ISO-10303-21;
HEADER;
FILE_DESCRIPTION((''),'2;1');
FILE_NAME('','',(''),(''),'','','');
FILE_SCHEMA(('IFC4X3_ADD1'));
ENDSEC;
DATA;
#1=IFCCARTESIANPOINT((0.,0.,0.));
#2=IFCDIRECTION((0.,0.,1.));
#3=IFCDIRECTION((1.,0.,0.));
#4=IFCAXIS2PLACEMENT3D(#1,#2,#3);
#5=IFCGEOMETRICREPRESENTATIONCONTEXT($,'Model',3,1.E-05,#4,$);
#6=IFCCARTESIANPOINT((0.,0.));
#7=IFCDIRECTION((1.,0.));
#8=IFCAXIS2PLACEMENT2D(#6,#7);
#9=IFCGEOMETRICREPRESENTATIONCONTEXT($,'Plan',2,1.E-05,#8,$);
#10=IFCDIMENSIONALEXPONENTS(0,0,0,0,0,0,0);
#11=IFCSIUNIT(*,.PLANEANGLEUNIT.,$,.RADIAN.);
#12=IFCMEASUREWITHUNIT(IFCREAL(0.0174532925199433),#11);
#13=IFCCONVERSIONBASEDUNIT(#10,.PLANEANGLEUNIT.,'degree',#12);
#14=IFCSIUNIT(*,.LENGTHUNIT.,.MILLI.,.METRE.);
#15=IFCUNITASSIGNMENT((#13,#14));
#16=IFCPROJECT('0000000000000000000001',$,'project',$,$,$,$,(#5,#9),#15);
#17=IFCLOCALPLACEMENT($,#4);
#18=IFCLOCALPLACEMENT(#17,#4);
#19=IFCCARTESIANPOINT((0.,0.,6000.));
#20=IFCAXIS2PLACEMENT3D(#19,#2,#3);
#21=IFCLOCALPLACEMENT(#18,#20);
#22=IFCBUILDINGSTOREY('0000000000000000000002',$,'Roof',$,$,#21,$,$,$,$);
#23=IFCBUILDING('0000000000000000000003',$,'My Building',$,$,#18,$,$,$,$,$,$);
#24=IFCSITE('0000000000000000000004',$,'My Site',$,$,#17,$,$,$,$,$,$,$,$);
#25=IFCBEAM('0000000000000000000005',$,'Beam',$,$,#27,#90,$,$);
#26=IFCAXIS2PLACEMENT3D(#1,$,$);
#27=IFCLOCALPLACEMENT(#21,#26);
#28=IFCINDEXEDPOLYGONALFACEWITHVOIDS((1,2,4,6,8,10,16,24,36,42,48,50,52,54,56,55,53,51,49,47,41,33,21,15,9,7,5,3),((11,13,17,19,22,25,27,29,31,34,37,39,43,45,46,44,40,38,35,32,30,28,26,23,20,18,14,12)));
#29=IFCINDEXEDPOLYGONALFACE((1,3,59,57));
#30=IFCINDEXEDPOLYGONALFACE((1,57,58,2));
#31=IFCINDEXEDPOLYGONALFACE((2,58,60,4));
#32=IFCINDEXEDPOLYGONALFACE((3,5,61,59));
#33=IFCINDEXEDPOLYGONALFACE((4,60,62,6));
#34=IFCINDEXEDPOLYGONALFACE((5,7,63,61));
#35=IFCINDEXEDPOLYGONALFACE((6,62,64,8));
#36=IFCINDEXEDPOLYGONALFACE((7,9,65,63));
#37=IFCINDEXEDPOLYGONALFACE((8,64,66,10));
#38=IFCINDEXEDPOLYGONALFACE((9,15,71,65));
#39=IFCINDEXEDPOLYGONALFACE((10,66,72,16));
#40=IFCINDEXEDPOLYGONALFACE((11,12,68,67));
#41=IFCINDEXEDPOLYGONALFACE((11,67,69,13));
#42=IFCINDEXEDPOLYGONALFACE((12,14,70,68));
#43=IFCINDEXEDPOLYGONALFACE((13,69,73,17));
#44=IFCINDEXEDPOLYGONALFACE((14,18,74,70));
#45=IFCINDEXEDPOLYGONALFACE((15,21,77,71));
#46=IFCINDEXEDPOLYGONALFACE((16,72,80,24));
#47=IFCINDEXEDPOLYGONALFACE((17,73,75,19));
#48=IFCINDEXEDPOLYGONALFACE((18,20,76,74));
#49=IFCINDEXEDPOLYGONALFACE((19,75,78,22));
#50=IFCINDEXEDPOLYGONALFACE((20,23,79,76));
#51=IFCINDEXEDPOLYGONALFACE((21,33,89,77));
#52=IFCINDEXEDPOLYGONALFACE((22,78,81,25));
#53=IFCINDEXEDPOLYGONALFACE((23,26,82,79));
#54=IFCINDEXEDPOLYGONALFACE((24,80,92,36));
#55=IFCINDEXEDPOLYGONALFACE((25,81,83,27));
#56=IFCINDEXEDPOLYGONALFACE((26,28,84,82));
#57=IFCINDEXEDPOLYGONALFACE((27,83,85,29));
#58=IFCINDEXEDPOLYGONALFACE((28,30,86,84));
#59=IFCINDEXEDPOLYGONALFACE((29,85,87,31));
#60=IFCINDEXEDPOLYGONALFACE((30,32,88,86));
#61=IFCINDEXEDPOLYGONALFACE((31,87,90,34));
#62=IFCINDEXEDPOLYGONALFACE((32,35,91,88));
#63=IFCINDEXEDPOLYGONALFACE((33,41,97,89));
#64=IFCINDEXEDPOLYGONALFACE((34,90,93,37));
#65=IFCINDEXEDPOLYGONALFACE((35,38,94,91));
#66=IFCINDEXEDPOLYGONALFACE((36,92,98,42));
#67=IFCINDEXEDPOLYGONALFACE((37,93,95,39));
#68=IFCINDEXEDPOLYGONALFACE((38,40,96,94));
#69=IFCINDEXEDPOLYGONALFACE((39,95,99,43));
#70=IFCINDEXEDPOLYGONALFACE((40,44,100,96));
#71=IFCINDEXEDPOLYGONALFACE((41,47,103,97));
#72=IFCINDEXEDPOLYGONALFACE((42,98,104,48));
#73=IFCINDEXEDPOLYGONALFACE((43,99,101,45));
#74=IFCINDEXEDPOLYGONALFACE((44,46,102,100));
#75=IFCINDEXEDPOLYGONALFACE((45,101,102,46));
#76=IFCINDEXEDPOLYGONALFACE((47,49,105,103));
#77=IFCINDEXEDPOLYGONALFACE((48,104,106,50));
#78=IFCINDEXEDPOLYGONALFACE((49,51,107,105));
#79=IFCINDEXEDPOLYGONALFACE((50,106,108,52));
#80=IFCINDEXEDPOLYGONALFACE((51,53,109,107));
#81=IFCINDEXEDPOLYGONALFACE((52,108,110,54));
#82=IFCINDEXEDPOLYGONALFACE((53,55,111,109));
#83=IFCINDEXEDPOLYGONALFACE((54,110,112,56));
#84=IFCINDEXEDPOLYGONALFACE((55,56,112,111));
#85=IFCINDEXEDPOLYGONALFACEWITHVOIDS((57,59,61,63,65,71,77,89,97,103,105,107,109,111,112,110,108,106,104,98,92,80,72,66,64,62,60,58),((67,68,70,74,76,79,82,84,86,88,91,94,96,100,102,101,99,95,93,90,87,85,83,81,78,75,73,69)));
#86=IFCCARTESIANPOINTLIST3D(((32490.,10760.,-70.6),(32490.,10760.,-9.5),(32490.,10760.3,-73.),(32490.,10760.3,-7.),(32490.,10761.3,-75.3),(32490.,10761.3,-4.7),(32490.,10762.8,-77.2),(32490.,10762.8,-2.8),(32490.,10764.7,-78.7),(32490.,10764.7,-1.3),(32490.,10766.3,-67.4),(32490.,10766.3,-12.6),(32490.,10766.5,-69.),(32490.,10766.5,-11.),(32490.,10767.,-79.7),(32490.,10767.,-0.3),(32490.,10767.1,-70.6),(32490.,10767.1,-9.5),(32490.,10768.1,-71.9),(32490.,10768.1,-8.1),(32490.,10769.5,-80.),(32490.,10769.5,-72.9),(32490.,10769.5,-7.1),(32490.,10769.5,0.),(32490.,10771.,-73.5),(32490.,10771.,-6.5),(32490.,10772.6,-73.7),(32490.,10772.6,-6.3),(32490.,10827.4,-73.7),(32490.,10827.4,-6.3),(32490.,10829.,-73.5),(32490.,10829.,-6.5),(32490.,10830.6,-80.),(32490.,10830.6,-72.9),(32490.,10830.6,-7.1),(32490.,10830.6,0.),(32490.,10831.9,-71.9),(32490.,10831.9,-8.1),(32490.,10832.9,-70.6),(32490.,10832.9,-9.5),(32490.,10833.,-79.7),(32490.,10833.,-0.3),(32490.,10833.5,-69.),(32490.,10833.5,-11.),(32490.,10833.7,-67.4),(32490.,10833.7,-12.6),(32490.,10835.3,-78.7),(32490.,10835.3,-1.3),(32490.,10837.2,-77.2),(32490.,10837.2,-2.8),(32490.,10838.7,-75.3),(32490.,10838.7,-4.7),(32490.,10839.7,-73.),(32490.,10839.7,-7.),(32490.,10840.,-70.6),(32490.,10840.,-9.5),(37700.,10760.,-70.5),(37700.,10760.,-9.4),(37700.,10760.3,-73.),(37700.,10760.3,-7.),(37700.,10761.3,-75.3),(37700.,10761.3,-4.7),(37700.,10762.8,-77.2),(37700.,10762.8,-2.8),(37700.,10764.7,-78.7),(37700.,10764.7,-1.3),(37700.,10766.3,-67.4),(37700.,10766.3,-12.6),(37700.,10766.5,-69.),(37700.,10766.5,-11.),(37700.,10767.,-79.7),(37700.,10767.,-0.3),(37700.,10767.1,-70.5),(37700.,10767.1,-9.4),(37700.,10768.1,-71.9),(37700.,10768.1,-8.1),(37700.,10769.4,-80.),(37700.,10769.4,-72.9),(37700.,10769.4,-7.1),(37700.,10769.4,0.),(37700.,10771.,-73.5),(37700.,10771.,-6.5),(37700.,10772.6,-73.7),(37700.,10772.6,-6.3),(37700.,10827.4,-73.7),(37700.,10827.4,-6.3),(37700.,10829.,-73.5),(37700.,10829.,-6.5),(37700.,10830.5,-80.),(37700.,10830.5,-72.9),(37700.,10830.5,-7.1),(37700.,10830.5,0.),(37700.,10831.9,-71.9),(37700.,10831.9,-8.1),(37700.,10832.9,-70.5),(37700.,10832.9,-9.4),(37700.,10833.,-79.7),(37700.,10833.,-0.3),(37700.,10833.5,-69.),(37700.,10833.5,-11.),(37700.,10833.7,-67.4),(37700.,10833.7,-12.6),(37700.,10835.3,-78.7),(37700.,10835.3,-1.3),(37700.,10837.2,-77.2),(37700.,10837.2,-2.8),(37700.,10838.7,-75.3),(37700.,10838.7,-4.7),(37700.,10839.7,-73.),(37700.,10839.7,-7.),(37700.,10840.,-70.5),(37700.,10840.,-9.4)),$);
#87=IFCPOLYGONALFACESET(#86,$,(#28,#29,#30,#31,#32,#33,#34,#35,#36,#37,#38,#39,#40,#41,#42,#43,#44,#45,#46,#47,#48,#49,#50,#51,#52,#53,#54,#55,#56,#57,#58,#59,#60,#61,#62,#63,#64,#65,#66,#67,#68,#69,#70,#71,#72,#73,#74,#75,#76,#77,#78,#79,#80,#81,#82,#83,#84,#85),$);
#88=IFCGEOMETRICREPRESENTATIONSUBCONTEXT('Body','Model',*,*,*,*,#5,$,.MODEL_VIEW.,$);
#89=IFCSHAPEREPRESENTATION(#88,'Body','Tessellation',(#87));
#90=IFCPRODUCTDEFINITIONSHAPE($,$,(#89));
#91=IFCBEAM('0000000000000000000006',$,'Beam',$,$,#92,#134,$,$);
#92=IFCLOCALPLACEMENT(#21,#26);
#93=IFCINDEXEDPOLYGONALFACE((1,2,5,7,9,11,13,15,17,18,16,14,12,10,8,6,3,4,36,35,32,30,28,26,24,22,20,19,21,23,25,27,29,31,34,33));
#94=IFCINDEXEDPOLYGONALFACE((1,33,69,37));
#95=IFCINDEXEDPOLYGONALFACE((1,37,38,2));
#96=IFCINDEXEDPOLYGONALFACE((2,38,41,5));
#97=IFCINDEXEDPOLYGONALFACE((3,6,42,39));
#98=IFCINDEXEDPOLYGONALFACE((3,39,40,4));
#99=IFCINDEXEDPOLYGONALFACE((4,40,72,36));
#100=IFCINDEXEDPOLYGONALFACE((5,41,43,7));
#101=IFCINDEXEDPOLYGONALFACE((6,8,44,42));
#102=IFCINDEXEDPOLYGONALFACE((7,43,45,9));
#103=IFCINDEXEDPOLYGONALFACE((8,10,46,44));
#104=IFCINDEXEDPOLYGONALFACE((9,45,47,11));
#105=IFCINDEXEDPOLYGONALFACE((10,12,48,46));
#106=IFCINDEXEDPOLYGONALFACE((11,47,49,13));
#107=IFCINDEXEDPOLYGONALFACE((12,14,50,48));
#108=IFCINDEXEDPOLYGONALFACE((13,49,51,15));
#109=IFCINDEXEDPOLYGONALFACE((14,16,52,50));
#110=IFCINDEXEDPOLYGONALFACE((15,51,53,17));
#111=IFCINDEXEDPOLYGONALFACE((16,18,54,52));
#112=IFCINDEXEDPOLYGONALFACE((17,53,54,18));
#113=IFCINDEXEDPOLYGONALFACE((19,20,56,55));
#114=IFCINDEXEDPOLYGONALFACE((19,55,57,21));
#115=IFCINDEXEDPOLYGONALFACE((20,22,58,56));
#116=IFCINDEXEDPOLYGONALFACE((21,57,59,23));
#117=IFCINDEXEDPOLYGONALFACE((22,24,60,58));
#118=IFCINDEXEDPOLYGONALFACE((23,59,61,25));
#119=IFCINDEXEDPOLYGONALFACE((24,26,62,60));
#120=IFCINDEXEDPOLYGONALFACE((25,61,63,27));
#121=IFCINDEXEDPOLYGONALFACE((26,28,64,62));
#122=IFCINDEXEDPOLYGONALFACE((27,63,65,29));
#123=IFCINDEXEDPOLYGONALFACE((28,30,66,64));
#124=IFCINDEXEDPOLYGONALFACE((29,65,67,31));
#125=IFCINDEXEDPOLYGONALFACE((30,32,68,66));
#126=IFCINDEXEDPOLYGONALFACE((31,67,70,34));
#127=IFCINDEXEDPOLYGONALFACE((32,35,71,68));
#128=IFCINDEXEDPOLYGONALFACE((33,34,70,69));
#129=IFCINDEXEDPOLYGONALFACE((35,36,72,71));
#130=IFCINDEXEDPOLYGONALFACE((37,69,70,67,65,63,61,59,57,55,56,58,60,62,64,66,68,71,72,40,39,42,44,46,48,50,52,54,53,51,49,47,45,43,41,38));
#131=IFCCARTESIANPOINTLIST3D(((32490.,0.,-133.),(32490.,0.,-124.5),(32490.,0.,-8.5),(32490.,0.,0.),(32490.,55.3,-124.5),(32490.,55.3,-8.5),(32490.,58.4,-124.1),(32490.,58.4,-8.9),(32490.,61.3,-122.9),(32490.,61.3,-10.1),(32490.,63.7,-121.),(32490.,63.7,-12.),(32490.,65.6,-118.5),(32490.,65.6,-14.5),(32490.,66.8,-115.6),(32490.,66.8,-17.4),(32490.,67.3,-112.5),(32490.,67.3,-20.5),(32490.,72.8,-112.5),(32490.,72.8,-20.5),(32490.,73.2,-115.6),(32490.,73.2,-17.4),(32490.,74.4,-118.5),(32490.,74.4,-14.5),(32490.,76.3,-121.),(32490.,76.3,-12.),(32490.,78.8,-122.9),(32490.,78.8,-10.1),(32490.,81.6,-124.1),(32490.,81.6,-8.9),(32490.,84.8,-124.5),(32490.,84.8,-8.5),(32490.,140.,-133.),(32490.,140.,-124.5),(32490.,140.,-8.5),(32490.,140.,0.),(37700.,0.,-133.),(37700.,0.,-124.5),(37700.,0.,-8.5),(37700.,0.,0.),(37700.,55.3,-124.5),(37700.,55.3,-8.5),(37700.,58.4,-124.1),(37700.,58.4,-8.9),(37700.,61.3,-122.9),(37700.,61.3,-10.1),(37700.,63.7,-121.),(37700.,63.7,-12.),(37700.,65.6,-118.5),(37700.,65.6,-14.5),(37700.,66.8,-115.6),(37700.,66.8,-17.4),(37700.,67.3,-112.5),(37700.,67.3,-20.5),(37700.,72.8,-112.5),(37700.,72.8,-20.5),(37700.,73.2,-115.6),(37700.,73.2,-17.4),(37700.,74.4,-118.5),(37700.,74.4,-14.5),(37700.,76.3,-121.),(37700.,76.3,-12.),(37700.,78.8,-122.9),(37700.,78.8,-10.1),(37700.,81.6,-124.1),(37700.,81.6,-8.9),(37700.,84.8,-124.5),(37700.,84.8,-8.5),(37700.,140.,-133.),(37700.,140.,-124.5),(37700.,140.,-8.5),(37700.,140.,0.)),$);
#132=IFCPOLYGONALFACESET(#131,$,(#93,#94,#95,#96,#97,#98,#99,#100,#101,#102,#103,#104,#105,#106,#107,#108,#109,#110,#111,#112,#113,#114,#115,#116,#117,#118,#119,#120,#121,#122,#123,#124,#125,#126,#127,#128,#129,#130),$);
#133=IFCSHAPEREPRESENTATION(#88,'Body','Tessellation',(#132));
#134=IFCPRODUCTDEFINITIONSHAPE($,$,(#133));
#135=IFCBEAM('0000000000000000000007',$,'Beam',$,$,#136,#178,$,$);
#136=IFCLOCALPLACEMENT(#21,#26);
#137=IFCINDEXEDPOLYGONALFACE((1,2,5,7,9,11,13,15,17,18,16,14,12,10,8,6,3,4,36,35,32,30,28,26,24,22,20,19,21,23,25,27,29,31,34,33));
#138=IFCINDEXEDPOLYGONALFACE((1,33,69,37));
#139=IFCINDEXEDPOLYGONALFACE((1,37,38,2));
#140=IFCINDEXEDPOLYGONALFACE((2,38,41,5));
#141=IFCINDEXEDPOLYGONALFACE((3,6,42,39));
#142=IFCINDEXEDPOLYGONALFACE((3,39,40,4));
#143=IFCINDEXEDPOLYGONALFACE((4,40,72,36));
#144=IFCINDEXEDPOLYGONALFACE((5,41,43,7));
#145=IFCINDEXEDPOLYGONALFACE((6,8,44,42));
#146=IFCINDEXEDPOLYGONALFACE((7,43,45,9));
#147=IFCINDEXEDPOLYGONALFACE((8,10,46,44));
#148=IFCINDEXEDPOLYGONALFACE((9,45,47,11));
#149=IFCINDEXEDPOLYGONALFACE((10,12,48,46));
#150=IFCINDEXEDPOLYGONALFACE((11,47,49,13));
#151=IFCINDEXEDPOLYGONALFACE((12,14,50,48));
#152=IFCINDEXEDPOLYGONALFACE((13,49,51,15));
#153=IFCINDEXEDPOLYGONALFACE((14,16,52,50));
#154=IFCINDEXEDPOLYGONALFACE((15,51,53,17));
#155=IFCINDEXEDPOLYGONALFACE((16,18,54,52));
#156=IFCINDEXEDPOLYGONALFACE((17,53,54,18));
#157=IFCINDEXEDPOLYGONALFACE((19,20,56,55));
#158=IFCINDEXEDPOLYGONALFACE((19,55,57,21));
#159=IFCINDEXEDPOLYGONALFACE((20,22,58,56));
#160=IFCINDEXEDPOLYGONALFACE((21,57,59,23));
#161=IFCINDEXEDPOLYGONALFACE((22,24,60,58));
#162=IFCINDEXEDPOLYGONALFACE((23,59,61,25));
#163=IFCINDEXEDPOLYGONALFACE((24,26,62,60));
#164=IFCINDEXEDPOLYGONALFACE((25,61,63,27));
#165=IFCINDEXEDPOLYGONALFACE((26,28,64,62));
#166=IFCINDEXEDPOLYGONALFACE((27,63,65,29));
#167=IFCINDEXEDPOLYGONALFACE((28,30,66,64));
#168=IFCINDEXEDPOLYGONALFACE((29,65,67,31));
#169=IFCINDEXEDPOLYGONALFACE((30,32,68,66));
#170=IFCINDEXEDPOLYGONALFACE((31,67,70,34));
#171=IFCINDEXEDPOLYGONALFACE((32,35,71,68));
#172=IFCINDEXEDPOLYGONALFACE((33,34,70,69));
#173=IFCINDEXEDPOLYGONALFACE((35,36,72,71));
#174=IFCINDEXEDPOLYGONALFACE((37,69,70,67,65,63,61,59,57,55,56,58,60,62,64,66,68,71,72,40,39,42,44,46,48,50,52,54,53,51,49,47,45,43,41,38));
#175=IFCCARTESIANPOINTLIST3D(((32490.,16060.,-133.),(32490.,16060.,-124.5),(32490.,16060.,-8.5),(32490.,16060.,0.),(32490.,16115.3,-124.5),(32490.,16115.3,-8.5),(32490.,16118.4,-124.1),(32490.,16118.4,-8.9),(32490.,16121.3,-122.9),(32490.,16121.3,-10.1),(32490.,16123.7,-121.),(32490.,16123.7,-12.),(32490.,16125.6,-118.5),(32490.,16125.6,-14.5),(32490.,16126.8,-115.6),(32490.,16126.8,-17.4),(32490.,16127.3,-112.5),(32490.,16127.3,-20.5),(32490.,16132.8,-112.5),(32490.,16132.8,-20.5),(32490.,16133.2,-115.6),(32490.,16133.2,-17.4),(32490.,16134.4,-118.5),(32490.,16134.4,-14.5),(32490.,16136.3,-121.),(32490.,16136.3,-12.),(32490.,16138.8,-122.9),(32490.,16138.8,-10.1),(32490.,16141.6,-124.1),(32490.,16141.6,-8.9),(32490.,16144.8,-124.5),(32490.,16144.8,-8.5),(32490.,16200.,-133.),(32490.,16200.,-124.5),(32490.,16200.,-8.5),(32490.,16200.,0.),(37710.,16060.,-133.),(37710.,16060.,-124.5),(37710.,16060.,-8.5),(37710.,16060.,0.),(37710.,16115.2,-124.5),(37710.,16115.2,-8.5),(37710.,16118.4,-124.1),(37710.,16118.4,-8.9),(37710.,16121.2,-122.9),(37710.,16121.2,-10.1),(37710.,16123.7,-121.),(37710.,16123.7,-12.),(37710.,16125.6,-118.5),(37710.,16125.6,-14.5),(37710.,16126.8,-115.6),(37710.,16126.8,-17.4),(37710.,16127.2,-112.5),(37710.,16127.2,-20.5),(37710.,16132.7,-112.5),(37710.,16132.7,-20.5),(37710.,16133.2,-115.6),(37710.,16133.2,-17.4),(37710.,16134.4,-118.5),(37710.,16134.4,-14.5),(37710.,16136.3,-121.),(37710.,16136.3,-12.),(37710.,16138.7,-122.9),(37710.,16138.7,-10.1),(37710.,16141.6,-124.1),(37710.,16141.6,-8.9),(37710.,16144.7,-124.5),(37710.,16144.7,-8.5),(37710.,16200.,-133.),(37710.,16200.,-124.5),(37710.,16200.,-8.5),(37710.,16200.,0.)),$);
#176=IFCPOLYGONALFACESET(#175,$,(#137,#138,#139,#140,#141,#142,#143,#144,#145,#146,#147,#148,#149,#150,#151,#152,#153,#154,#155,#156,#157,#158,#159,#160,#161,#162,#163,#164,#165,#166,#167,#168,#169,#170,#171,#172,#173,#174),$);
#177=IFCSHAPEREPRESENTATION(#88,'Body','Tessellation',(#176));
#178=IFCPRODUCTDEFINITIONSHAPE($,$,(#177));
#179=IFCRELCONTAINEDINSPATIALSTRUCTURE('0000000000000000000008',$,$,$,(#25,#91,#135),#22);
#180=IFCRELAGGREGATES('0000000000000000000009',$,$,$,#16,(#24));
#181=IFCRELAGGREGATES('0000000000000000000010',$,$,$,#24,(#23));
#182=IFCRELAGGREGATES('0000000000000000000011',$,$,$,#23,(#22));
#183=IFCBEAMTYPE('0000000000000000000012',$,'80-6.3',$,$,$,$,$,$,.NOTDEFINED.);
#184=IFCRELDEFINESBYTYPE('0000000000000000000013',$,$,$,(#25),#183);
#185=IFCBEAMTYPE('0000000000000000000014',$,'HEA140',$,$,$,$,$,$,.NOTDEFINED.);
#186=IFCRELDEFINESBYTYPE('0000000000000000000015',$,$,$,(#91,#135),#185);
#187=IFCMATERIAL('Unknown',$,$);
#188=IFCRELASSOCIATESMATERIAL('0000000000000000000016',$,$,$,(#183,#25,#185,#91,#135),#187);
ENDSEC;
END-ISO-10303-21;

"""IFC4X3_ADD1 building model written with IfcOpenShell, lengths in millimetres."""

from ifc_helpers import new_model, entity, si_unit, converted_unit, frame, origin_with_axes, origin_2d_with_axis, place, context, subcontext, project, spatial, hollow_rectangle, i_section, extrude, material, material_profile, profile_set, profile_usage, type_object, element, save


model = new_model("IFC4X3_ADD1")

# Units and contexts
model_context = context("Model", 3, precision=1e-05, world=origin_with_axes())
plan_context = context("Plan", 2, precision=1e-05, world=origin_2d_with_axis())
body_context = subcontext(model_context, "Body", "Model", "MODEL_VIEW")
ifc_project = project(units=[converted_unit("PLANEANGLEUNIT", "degree", entity("IfcReal", 0.0174532925199433), si_unit("PLANEANGLEUNIT", "RADIAN"), dimensions=[0, 0, 0, 0, 0, 0, 0]), si_unit("LENGTHUNIT", "METRE", prefix="MILLI")], contexts=[model_context, plan_context])

# Site, building, storey
site_placement = place(None, origin_with_axes())
site = spatial("IfcSite", under=ifc_project, at=site_placement, Name="My Site")
building_placement = place(site_placement, origin_with_axes())
building = spatial("IfcBuilding", under=site, at=building_placement, Name="My Building")
storey_placement = place(building_placement, frame((0.0, 0.0, 6000.0), z_axis=(0.0, 0.0, 1.0), x_axis=(1.0, 0.0, 0.0)))
storey = spatial("IfcBuildingStorey", under=building, at=storey_placement, Name="Roof")

# Beams
ifc_material = material(Name="Unknown")
ifc_material_profile_1 = material_profile(ifc_material, hollow_rectangle(XDim=80.0, YDim=80.0, WallThickness=6.3, InnerFilletRadius=6.3, OuterFilletRadius=9.4))
ifc_profile_set_1 = profile_set([ifc_material_profile_1])
beam_type_1 = type_object("IfcBeamType", Name="80-6.3", PredefinedType="NOTDEFINED", material=ifc_profile_set_1)
ifc_profile_usage_1 = profile_usage(ifc_profile_set_1, cardinal=8)
beam_1_placement = place(storey_placement, frame((32490.0, 10800.0, 0.0), z_axis=(1.0, 0.0, 0.0), x_axis=(0.0, 1.0, 0.0)))
element("IfcBeam", 1, at=beam_1_placement, inside=storey, type_object=beam_type_1, material=ifc_profile_usage_1, Name="Beam", context=body_context, shape_type="SweptSolid", body=[
    extrude(hollow_rectangle(XDim=80.0, YDim=80.0, WallThickness=6.3, InnerFilletRadius=6.3, OuterFilletRadius=9.4), frame((0.0, -40.0, 0.0), z_axis=(0.0, 0.0, 1.0), x_axis=(1.0, 0.0, 0.0)), (0.0, 0.0, 1.0), 5210.0),
])
ifc_material_profile_2 = material_profile(ifc_material, i_section(OverallWidth=140.0, OverallDepth=133.0, WebThickness=5.5, FlangeThickness=8.5, FilletRadius=12.0))
ifc_profile_set_2 = profile_set([ifc_material_profile_2])
ifc_profile_usage_2 = profile_usage(ifc_profile_set_2, cardinal=7)
beam_type_2 = type_object("IfcBeamType", Name="HEA140", PredefinedType="NOTDEFINED", material=ifc_profile_set_2)
beam_2_placement = place(storey_placement, frame((37700.0, 0.0, 0.0), z_axis=(-1.0, 0.0, 0.0), x_axis=(0.0, -1.0, 0.0)))
element("IfcBeam", 2, at=beam_2_placement, inside=storey, type_object=beam_type_2, material=ifc_profile_usage_2, Name="Beam", context=body_context, shape_type="SweptSolid", body=[
    extrude(i_section(OverallWidth=140.0, OverallDepth=133.0, WebThickness=5.5, FlangeThickness=8.5, FilletRadius=12.0), frame((-70.0, -66.5, 0.0), z_axis=(0.0, 0.0, 1.0), x_axis=(1.0, 0.0, 0.0)), (0.0, 0.0, 1.0), 5210.0),
])
ifc_profile_usage_3 = profile_usage(ifc_profile_set_2, cardinal=7)
beam_3_placement = place(storey_placement, frame((32490.0, 16200.0, 0.0), z_axis=(1.0, 0.0, 0.0), x_axis=(0.0, 1.0, 0.0)))
element("IfcBeam", 3, at=beam_3_placement, inside=storey, type_object=beam_type_2, material=ifc_profile_usage_3, Name="Beam", context=body_context, shape_type="SweptSolid", body=[
    extrude(i_section(OverallWidth=140.0, OverallDepth=133.0, WebThickness=5.5, FlangeThickness=8.5, FilletRadius=12.0), frame((-70.0, -66.5, 0.0), z_axis=(0.0, 0.0, 1.0), x_axis=(1.0, 0.0, 0.0)), (0.0, 0.0, 1.0), 5220.0),
])

save(model, "model.ifc")
